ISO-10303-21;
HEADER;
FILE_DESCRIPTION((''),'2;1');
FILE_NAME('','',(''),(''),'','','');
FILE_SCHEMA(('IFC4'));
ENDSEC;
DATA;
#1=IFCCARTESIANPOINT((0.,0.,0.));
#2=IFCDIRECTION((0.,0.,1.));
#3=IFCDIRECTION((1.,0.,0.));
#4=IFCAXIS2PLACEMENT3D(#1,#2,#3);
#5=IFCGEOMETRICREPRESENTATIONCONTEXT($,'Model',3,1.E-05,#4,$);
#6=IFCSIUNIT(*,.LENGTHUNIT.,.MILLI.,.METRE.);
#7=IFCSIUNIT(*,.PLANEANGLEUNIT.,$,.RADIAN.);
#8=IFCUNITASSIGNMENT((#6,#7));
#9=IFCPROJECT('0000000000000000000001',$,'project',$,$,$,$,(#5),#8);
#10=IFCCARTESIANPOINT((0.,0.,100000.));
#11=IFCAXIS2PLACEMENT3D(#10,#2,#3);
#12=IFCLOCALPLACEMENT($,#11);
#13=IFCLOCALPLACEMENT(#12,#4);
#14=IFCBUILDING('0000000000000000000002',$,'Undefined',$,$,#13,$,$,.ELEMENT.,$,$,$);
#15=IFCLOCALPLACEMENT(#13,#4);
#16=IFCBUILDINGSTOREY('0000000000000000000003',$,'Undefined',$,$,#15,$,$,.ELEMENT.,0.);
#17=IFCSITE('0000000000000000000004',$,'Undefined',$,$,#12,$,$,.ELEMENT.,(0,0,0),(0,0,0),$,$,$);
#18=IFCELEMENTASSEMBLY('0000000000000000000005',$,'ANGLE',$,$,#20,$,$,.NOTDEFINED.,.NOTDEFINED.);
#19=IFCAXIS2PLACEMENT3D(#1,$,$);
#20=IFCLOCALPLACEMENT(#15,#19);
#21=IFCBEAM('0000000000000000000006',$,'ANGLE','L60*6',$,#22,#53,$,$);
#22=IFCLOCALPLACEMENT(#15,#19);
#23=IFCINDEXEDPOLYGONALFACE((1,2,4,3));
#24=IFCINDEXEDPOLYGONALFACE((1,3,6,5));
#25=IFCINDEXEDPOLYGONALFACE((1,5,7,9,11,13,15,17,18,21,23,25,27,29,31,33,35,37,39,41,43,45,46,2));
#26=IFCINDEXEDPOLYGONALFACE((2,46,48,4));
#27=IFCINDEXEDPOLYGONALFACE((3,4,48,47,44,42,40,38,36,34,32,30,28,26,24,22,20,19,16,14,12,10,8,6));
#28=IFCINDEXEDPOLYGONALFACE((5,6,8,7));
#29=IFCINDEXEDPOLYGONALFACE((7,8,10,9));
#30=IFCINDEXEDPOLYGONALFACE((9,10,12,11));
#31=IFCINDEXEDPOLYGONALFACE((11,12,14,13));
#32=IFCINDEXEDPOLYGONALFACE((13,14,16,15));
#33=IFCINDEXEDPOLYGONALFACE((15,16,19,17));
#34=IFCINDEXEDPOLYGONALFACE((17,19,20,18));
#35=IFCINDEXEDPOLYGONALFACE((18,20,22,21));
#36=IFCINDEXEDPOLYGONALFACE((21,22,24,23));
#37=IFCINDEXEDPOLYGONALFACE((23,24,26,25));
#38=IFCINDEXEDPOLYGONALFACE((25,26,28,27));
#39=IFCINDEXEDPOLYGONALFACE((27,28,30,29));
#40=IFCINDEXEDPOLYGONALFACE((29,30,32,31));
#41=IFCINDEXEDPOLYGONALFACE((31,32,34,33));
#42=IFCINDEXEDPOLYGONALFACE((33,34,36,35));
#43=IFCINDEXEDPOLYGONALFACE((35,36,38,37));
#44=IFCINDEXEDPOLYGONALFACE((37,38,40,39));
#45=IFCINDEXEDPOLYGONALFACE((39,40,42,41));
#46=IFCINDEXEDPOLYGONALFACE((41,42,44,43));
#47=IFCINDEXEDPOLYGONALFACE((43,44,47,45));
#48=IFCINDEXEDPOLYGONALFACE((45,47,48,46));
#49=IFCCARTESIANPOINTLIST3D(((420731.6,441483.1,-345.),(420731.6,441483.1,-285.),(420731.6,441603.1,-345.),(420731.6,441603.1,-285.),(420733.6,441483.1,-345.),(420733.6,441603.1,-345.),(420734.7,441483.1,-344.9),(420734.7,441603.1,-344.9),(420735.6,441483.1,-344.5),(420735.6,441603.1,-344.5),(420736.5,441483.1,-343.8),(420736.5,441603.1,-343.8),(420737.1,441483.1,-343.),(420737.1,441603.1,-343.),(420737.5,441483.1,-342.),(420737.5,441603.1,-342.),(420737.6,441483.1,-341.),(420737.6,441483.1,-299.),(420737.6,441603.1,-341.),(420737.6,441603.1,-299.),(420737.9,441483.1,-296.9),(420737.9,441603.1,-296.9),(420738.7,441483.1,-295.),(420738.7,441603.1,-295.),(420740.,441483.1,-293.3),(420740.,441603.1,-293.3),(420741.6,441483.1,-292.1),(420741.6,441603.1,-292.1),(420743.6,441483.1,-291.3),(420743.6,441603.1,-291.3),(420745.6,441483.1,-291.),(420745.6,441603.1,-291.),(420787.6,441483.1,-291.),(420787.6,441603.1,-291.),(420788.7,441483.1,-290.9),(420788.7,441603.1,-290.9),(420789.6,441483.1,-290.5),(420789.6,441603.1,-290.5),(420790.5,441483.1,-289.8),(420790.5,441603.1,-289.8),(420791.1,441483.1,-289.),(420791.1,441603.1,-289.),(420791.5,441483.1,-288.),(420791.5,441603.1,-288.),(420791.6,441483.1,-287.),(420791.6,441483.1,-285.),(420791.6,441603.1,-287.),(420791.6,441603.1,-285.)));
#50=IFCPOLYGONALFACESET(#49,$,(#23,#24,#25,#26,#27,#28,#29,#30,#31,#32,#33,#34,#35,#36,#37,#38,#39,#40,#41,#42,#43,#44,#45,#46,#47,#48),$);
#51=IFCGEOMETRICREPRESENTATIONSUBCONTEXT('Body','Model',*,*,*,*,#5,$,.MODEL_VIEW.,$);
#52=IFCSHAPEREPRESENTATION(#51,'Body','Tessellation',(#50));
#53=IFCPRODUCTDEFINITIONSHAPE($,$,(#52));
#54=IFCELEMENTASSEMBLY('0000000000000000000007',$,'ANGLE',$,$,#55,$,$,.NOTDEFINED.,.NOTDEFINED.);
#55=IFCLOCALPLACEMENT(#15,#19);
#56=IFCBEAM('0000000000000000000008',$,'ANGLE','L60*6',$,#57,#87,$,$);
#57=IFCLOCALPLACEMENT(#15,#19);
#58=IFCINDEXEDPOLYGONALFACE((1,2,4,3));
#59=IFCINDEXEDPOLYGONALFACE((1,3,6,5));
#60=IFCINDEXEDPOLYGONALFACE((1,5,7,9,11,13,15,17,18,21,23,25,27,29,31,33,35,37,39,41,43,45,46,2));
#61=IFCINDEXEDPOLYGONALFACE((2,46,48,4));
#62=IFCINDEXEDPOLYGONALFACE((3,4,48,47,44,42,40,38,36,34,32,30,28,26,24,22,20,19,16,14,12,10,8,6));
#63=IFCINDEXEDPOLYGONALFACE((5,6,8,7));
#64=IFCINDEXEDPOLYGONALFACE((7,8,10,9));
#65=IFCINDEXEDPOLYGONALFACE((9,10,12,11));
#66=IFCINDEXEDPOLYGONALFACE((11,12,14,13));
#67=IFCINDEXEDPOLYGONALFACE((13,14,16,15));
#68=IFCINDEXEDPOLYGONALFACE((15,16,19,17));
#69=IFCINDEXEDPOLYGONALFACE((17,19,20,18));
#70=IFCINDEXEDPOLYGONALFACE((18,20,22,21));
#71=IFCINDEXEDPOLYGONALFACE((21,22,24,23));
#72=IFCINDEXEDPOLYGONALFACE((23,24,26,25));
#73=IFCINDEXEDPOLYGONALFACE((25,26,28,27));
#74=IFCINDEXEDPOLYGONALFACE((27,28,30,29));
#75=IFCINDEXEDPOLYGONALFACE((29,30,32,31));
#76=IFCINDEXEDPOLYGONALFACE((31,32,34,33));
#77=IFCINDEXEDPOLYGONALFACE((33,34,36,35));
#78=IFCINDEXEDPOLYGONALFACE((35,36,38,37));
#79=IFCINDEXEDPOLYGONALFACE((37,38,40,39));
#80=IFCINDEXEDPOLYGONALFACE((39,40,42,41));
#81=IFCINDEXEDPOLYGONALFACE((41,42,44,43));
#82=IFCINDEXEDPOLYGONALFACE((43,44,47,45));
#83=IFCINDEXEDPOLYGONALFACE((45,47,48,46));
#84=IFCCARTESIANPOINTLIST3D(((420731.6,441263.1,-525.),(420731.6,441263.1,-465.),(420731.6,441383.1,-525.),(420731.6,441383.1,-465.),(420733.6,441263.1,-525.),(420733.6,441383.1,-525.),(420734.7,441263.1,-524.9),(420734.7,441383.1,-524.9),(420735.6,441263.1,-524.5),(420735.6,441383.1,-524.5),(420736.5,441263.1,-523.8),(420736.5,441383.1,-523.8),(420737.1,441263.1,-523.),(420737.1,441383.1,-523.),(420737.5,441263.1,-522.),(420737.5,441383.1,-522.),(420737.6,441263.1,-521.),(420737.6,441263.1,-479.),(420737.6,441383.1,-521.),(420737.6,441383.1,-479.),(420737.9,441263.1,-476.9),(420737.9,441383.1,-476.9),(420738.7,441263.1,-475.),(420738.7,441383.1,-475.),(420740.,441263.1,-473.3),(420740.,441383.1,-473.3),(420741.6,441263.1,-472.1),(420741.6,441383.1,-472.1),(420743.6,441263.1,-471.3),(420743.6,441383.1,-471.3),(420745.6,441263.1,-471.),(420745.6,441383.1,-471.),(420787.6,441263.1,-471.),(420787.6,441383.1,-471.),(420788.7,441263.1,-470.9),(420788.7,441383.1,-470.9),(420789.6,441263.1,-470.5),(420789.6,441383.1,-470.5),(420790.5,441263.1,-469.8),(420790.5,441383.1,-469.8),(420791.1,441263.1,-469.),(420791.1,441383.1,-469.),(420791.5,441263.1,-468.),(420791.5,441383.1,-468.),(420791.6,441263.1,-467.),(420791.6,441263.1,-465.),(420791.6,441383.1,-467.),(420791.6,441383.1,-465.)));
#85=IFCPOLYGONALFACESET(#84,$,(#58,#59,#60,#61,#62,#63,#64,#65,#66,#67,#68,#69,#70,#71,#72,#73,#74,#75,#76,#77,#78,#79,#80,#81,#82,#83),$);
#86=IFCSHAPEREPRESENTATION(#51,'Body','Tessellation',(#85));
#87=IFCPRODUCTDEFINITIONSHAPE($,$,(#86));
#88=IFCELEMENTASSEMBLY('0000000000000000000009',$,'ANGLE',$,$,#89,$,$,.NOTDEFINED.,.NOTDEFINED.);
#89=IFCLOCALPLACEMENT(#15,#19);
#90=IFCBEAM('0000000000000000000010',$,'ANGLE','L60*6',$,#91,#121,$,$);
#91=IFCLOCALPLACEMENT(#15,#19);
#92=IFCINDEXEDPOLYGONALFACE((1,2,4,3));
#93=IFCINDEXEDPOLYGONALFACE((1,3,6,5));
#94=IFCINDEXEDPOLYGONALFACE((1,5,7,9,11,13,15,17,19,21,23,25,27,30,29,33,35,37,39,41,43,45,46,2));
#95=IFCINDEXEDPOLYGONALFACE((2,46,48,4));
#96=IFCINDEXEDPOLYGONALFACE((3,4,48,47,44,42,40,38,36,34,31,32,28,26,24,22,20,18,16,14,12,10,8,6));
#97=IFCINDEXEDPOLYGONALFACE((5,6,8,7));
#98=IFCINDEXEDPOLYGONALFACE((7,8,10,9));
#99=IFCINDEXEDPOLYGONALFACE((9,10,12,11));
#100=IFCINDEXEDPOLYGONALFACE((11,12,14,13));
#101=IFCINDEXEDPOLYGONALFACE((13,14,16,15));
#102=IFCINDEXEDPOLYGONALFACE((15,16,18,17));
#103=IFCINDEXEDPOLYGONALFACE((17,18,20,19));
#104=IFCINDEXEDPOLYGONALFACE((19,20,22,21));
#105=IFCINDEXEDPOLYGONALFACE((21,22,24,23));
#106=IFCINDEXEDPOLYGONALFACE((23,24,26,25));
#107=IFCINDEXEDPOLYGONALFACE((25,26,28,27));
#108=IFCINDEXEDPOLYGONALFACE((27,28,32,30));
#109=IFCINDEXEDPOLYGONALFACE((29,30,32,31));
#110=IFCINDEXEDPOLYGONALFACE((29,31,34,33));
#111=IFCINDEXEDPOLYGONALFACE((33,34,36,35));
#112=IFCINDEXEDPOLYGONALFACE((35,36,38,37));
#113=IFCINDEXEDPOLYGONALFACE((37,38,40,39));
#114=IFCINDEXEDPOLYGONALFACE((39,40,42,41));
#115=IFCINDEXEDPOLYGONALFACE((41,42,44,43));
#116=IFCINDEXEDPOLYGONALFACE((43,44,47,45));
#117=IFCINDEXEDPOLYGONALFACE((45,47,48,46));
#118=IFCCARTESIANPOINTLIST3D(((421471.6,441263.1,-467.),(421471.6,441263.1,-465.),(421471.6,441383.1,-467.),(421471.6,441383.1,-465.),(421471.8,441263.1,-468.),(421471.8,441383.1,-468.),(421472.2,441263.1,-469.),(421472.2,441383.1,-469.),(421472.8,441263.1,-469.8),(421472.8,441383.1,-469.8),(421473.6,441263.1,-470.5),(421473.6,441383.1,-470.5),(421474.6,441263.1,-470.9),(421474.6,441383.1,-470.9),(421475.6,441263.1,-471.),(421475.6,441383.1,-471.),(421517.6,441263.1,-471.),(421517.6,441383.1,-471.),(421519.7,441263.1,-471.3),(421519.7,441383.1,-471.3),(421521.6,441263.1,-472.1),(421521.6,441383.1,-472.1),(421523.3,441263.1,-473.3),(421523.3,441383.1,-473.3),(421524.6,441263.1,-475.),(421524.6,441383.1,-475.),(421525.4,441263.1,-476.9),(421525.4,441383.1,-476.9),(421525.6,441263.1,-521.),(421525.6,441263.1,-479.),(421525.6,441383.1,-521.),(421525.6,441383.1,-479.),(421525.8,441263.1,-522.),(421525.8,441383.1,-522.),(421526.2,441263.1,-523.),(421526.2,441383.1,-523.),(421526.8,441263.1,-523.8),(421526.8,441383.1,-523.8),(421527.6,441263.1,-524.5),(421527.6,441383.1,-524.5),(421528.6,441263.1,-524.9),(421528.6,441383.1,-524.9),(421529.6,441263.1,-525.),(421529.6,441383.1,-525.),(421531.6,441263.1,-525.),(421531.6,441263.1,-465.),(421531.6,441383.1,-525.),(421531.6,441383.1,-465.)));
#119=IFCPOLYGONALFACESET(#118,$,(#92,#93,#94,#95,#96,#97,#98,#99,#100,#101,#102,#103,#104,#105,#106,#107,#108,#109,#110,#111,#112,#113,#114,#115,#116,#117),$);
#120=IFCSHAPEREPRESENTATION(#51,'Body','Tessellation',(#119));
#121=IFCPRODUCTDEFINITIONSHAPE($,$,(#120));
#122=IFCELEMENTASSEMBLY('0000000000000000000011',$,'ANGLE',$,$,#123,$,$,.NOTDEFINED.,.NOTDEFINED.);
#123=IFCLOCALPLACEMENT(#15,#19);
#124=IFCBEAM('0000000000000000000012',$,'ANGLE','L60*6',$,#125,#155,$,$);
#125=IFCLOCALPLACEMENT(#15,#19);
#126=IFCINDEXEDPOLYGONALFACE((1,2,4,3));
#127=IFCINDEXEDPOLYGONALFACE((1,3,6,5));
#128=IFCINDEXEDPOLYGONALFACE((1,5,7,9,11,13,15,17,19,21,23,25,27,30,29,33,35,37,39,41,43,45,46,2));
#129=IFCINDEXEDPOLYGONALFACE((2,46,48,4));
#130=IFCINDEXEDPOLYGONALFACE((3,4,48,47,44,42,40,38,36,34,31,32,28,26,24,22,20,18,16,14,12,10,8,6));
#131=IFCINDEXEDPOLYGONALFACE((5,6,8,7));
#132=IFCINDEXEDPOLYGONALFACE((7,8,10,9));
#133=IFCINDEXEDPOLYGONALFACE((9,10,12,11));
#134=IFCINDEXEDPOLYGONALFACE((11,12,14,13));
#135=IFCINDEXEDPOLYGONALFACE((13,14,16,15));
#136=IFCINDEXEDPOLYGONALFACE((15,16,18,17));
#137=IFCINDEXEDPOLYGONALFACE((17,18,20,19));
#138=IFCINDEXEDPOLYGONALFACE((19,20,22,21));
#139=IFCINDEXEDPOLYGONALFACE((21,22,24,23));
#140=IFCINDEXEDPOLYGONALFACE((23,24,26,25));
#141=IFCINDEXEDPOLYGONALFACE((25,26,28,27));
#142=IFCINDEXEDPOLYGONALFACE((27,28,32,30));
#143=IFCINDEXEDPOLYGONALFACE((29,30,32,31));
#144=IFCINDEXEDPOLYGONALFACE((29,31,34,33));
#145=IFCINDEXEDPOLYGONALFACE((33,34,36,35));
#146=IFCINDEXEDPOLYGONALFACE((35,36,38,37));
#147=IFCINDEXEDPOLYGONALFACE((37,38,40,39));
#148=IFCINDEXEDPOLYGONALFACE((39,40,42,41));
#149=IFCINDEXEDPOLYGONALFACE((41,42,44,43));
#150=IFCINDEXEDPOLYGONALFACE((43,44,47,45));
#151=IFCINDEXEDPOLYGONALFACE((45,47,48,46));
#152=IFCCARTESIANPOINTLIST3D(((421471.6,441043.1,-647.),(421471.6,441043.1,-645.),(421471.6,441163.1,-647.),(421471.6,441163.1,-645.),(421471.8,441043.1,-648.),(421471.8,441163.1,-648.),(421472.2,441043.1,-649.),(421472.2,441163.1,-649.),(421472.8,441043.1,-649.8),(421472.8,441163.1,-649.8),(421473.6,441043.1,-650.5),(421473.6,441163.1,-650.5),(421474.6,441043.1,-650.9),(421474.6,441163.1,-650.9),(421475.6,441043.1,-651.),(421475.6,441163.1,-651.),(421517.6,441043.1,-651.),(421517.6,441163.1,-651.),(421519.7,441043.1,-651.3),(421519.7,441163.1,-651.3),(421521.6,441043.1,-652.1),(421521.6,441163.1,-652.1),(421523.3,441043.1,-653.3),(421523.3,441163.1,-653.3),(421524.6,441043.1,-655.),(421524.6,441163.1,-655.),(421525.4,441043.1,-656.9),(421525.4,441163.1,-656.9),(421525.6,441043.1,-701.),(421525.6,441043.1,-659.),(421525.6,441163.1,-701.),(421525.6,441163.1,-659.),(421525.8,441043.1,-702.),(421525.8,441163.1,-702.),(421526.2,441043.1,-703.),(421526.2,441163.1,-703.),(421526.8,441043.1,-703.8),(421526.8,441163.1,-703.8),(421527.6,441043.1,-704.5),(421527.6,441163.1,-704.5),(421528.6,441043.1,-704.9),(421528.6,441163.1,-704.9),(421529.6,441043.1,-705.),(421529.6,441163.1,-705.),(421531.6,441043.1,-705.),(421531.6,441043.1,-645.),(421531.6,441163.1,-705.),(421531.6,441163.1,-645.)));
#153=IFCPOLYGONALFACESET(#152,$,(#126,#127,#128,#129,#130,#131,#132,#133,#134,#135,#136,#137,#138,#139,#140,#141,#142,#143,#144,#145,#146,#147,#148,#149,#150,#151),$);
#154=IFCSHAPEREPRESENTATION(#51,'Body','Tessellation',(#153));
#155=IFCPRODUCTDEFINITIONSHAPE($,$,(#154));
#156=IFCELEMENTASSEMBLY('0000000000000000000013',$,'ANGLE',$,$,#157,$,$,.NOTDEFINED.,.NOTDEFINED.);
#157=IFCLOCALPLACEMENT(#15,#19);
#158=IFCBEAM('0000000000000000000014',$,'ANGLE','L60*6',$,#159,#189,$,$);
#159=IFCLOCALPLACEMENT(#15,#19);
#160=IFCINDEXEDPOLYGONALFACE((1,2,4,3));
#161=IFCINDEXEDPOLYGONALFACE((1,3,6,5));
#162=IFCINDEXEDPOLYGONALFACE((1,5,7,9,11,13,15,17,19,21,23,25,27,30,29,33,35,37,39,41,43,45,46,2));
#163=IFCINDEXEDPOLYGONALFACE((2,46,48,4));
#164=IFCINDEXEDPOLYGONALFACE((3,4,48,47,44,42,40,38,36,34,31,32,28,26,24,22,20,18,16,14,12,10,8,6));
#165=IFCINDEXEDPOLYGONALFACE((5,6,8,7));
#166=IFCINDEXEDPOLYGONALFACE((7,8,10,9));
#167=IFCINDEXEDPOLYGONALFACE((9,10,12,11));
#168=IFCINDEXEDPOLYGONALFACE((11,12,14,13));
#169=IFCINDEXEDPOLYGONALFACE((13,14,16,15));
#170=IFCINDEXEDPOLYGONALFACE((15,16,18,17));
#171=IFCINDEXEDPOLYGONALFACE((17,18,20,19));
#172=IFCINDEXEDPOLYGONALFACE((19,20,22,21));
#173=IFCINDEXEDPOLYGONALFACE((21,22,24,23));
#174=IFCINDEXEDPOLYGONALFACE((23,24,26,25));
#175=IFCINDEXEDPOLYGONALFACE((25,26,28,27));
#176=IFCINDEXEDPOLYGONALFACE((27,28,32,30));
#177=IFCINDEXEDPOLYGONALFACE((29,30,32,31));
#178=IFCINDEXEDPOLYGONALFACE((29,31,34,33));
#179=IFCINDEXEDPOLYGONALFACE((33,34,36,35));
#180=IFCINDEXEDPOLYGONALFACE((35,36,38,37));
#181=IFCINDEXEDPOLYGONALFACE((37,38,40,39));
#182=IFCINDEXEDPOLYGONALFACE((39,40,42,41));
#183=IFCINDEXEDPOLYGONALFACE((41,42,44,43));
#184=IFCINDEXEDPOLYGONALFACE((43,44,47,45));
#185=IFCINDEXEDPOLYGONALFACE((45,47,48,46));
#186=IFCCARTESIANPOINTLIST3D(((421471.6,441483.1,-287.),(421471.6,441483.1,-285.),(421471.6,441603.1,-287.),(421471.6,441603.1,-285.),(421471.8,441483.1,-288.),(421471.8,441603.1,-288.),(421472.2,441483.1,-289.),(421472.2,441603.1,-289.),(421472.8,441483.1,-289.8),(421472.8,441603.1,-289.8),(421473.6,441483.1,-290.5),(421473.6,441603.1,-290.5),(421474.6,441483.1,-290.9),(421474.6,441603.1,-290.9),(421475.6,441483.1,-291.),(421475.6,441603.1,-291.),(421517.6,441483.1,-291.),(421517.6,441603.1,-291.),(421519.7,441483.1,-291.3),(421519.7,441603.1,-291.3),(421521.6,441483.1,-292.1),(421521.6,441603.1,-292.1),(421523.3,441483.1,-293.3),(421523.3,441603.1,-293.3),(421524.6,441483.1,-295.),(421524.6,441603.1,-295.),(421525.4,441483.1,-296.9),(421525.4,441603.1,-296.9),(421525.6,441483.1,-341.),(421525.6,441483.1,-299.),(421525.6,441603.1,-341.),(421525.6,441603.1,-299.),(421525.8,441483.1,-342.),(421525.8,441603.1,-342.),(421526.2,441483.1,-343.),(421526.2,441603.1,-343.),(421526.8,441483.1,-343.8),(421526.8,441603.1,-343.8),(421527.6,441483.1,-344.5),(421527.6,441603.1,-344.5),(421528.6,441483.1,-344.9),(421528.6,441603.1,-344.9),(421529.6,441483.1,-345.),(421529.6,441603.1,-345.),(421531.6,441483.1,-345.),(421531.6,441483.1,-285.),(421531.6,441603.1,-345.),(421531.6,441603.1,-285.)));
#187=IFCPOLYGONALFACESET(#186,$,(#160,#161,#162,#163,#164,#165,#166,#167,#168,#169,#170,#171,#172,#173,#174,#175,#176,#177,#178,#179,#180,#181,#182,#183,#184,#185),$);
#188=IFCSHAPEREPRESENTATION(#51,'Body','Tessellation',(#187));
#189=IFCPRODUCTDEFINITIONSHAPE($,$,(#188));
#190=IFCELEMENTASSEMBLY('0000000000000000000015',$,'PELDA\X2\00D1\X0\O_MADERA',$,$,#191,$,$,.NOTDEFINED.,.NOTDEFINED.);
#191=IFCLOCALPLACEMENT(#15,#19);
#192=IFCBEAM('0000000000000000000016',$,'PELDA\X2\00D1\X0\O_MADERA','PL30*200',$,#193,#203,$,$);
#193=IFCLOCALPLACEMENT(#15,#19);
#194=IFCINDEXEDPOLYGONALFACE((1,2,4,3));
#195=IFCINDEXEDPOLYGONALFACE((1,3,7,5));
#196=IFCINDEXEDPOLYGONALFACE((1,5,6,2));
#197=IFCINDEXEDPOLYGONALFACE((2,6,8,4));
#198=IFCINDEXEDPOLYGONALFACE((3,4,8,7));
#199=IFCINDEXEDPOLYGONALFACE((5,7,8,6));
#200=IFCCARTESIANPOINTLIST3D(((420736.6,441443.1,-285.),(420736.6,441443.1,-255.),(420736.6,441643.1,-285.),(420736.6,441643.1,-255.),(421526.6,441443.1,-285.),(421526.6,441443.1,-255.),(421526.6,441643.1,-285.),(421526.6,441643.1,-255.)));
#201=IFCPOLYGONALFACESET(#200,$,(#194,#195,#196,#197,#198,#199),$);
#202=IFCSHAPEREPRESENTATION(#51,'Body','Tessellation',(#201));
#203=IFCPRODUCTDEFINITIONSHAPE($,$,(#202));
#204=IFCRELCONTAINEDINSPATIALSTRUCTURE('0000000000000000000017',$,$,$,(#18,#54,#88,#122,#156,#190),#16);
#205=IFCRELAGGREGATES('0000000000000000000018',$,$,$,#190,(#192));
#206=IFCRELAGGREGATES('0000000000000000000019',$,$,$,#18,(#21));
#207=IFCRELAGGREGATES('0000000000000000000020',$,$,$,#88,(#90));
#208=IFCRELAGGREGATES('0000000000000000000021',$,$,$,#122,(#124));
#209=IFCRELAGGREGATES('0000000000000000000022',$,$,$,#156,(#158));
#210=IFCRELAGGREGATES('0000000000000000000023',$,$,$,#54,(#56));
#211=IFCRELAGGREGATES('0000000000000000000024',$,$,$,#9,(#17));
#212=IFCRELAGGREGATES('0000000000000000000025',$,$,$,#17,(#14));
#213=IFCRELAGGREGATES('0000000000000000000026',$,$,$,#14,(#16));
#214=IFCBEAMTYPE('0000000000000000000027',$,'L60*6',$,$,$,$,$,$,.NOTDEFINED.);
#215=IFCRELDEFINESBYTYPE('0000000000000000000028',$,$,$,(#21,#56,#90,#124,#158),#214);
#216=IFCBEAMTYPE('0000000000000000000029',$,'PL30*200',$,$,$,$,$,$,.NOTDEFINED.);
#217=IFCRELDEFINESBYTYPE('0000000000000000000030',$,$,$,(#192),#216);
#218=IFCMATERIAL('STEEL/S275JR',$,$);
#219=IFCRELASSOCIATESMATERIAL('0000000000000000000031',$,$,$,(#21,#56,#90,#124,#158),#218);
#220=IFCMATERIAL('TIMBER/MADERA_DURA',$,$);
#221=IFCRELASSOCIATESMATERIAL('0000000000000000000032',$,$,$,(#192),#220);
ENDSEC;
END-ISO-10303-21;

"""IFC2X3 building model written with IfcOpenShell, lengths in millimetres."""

from ifc_helpers import new_model, si_unit, frame, origin_with_axes, origin_2d_with_axis, place, context, subcontext, project, spatial, rectangle, l_section, extrude, material, type_object, element, aggregate, save


model = new_model("IFC2X3")

# Units and contexts
model_context = context("Model", 3, precision=1e-05, world=origin_with_axes())
body_context = subcontext(model_context, "Body", "Model", "MODEL_VIEW")
ifc_project = project(units=[si_unit("LENGTHUNIT", "METRE", prefix="MILLI"), si_unit("PLANEANGLEUNIT", "RADIAN")], contexts=[model_context])

# Site, building, storey
site_placement = place(None, frame((0.0, 0.0, 100000.0), z_axis=(0.0, 0.0, 1.0), x_axis=(1.0, 0.0, 0.0)))
site = spatial("IfcSite", under=ifc_project, at=site_placement, Name="Undefined", CompositionType="ELEMENT", RefLatitude=(0, 0, 0), RefLongitude=(0, 0, 0))
building_placement = place(site_placement, origin_with_axes())
building = spatial("IfcBuilding", under=site, at=building_placement, Name="Undefined", CompositionType="ELEMENT")
storey_placement = place(building_placement, origin_with_axes())
storey = spatial("IfcBuildingStorey", under=building, at=storey_placement, Name="Undefined", CompositionType="ELEMENT", Elevation=0.0)

# Shared definitions
ifc_material_1 = material(Name="STEEL/S275JR")

# Element assemblies, beams
assembly_1_placement = place(storey_placement, origin_with_axes())
assembly_1 = element("IfcElementAssembly", 1, at=assembly_1_placement, inside=storey, Name="ANGLE", AssemblyPlace="NOTDEFINED", PredefinedType="NOTDEFINED")
beam_type_1 = type_object("IfcBeamType", Name="L60*6", PredefinedType="NOTDEFINED")
beam_1_placement = place(assembly_1_placement, frame((420761.6, 441483.1, -315.0), z_axis=(1.0, -0.000001, 0.0), x_axis=(0.000001, 1.0, 0.0)))
beam_1 = element("IfcBeam", 2, at=beam_1_placement, type_object=beam_type_1, material=ifc_material_1, Name="ANGLE", Description="L60*6", context=body_context, shape_type="SweptSolid", body=[
    extrude(l_section(Depth=60.0, Width=60.0, Thickness=6.0, FilletRadius=8.0, EdgeRadius=4.0, at=origin_2d_with_axis()), frame((120.0, 0.0, 0.0), z_axis=(-1.0, 0.0, 0.0), x_axis=(0.0, -1.0, 0.0)), (0.0, 0.0, 1.0), 120.0),
])
assembly_2_placement = place(storey_placement, origin_with_axes())
assembly_2 = element("IfcElementAssembly", 3, at=assembly_2_placement, inside=storey, Name="ANGLE", AssemblyPlace="NOTDEFINED", PredefinedType="NOTDEFINED")
beam_2_placement = place(assembly_2_placement, frame((420761.6, 441263.1, -495.0), z_axis=(1.0, -0.000001, 0.0), x_axis=(0.000001, 1.0, 0.0)))
beam_2 = element("IfcBeam", 4, at=beam_2_placement, type_object=beam_type_1, material=ifc_material_1, Name="ANGLE", Description="L60*6", context=body_context, shape_type="SweptSolid", body=[
    extrude(l_section(Depth=60.0, Width=60.0, Thickness=6.0, FilletRadius=8.0, EdgeRadius=4.0, at=origin_2d_with_axis()), frame((120.0, 0.0, 0.0), z_axis=(-1.0, 0.0, 0.0), x_axis=(0.0, -1.0, 0.0)), (0.0, 0.0, 1.0), 120.0),
])
assembly_3_placement = place(storey_placement, origin_with_axes())
assembly_3 = element("IfcElementAssembly", 5, at=assembly_3_placement, inside=storey, Name="ANGLE", AssemblyPlace="NOTDEFINED", PredefinedType="NOTDEFINED")
beam_3_placement = place(assembly_3_placement, frame((421501.6, 441383.1, -495.0), z_axis=(-1.0, 0.000001, 0.0), x_axis=(-0.000001, -1.0, 0.0)))
beam_3 = element("IfcBeam", 6, at=beam_3_placement, type_object=beam_type_1, material=ifc_material_1, Name="ANGLE", Description="L60*6", context=body_context, shape_type="SweptSolid", body=[
    extrude(l_section(Depth=60.0, Width=60.0, Thickness=6.0, FilletRadius=8.0, EdgeRadius=4.0, at=origin_2d_with_axis()), frame((120.0, 0.0, 0.0), z_axis=(-1.0, 0.0, 0.0), x_axis=(0.0, -1.0, 0.0)), (0.0, 0.0, 1.0), 120.0),
])
assembly_4_placement = place(storey_placement, origin_with_axes())
assembly_4 = element("IfcElementAssembly", 7, at=assembly_4_placement, inside=storey, Name="ANGLE", AssemblyPlace="NOTDEFINED", PredefinedType="NOTDEFINED")
beam_4_placement = place(assembly_4_placement, frame((421501.6, 441163.1, -675.0), z_axis=(-1.0, 0.000001, 0.0), x_axis=(-0.000001, -1.0, 0.0)))
beam_4 = element("IfcBeam", 8, at=beam_4_placement, type_object=beam_type_1, material=ifc_material_1, Name="ANGLE", Description="L60*6", context=body_context, shape_type="SweptSolid", body=[
    extrude(l_section(Depth=60.0, Width=60.0, Thickness=6.0, FilletRadius=8.0, EdgeRadius=4.0, at=origin_2d_with_axis()), frame((120.0, 0.0, 0.0), z_axis=(-1.0, 0.0, 0.0), x_axis=(0.0, -1.0, 0.0)), (0.0, 0.0, 1.0), 120.0),
])
assembly_5_placement = place(storey_placement, origin_with_axes())
assembly_5 = element("IfcElementAssembly", 9, at=assembly_5_placement, inside=storey, Name="ANGLE", AssemblyPlace="NOTDEFINED", PredefinedType="NOTDEFINED")
beam_5_placement = place(assembly_5_placement, frame((421501.6, 441603.1, -315.0), z_axis=(-1.0, 0.000001, 0.0), x_axis=(-0.000001, -1.0, 0.0)))
beam_5 = element("IfcBeam", 10, at=beam_5_placement, type_object=beam_type_1, material=ifc_material_1, Name="ANGLE", Description="L60*6", context=body_context, shape_type="SweptSolid", body=[
    extrude(l_section(Depth=60.0, Width=60.0, Thickness=6.0, FilletRadius=8.0, EdgeRadius=4.0, at=origin_2d_with_axis()), frame((120.0, 0.0, 0.0), z_axis=(-1.0, 0.0, 0.0), x_axis=(0.0, -1.0, 0.0)), (0.0, 0.0, 1.0), 120.0),
])
assembly_6_placement = place(storey_placement, origin_with_axes())
assembly_6 = element("IfcElementAssembly", 11, at=assembly_6_placement, inside=storey, Name="PELDAÑO_MADERA", AssemblyPlace="NOTDEFINED", PredefinedType="NOTDEFINED")
ifc_material_2 = material(Name="TIMBER/MADERA_DURA")
beam_type_2 = type_object("IfcBeamType", Name="PL30*200", PredefinedType="NOTDEFINED")
beam_6_placement = place(assembly_6_placement, frame((421526.6, 441543.1, -270.0), z_axis=(0.000001, 1.0, 0.0), x_axis=(-1.0, 0.000001, 0.0)))
beam_6 = element("IfcBeam", 12, at=beam_6_placement, type_object=beam_type_2, material=ifc_material_2, Name="PELDAÑO_MADERA", Description="PL30*200", context=body_context, shape_type="SweptSolid", body=[
    extrude(rectangle(XDim=30.0, YDim=200.0, at=origin_2d_with_axis()), frame((790.0, 0.0, 0.0), z_axis=(-1.0, 0.0, 0.0), x_axis=(0.0, -1.0, 0.0)), (0.0, 0.0, 1.0), 790.0),
])
aggregate(assembly_6, [beam_6])

aggregate(assembly_1, [beam_1])
aggregate(assembly_3, [beam_3])
aggregate(assembly_4, [beam_4])
aggregate(assembly_5, [beam_5])
aggregate(assembly_2, [beam_2])

save(model, "model.ifc")
